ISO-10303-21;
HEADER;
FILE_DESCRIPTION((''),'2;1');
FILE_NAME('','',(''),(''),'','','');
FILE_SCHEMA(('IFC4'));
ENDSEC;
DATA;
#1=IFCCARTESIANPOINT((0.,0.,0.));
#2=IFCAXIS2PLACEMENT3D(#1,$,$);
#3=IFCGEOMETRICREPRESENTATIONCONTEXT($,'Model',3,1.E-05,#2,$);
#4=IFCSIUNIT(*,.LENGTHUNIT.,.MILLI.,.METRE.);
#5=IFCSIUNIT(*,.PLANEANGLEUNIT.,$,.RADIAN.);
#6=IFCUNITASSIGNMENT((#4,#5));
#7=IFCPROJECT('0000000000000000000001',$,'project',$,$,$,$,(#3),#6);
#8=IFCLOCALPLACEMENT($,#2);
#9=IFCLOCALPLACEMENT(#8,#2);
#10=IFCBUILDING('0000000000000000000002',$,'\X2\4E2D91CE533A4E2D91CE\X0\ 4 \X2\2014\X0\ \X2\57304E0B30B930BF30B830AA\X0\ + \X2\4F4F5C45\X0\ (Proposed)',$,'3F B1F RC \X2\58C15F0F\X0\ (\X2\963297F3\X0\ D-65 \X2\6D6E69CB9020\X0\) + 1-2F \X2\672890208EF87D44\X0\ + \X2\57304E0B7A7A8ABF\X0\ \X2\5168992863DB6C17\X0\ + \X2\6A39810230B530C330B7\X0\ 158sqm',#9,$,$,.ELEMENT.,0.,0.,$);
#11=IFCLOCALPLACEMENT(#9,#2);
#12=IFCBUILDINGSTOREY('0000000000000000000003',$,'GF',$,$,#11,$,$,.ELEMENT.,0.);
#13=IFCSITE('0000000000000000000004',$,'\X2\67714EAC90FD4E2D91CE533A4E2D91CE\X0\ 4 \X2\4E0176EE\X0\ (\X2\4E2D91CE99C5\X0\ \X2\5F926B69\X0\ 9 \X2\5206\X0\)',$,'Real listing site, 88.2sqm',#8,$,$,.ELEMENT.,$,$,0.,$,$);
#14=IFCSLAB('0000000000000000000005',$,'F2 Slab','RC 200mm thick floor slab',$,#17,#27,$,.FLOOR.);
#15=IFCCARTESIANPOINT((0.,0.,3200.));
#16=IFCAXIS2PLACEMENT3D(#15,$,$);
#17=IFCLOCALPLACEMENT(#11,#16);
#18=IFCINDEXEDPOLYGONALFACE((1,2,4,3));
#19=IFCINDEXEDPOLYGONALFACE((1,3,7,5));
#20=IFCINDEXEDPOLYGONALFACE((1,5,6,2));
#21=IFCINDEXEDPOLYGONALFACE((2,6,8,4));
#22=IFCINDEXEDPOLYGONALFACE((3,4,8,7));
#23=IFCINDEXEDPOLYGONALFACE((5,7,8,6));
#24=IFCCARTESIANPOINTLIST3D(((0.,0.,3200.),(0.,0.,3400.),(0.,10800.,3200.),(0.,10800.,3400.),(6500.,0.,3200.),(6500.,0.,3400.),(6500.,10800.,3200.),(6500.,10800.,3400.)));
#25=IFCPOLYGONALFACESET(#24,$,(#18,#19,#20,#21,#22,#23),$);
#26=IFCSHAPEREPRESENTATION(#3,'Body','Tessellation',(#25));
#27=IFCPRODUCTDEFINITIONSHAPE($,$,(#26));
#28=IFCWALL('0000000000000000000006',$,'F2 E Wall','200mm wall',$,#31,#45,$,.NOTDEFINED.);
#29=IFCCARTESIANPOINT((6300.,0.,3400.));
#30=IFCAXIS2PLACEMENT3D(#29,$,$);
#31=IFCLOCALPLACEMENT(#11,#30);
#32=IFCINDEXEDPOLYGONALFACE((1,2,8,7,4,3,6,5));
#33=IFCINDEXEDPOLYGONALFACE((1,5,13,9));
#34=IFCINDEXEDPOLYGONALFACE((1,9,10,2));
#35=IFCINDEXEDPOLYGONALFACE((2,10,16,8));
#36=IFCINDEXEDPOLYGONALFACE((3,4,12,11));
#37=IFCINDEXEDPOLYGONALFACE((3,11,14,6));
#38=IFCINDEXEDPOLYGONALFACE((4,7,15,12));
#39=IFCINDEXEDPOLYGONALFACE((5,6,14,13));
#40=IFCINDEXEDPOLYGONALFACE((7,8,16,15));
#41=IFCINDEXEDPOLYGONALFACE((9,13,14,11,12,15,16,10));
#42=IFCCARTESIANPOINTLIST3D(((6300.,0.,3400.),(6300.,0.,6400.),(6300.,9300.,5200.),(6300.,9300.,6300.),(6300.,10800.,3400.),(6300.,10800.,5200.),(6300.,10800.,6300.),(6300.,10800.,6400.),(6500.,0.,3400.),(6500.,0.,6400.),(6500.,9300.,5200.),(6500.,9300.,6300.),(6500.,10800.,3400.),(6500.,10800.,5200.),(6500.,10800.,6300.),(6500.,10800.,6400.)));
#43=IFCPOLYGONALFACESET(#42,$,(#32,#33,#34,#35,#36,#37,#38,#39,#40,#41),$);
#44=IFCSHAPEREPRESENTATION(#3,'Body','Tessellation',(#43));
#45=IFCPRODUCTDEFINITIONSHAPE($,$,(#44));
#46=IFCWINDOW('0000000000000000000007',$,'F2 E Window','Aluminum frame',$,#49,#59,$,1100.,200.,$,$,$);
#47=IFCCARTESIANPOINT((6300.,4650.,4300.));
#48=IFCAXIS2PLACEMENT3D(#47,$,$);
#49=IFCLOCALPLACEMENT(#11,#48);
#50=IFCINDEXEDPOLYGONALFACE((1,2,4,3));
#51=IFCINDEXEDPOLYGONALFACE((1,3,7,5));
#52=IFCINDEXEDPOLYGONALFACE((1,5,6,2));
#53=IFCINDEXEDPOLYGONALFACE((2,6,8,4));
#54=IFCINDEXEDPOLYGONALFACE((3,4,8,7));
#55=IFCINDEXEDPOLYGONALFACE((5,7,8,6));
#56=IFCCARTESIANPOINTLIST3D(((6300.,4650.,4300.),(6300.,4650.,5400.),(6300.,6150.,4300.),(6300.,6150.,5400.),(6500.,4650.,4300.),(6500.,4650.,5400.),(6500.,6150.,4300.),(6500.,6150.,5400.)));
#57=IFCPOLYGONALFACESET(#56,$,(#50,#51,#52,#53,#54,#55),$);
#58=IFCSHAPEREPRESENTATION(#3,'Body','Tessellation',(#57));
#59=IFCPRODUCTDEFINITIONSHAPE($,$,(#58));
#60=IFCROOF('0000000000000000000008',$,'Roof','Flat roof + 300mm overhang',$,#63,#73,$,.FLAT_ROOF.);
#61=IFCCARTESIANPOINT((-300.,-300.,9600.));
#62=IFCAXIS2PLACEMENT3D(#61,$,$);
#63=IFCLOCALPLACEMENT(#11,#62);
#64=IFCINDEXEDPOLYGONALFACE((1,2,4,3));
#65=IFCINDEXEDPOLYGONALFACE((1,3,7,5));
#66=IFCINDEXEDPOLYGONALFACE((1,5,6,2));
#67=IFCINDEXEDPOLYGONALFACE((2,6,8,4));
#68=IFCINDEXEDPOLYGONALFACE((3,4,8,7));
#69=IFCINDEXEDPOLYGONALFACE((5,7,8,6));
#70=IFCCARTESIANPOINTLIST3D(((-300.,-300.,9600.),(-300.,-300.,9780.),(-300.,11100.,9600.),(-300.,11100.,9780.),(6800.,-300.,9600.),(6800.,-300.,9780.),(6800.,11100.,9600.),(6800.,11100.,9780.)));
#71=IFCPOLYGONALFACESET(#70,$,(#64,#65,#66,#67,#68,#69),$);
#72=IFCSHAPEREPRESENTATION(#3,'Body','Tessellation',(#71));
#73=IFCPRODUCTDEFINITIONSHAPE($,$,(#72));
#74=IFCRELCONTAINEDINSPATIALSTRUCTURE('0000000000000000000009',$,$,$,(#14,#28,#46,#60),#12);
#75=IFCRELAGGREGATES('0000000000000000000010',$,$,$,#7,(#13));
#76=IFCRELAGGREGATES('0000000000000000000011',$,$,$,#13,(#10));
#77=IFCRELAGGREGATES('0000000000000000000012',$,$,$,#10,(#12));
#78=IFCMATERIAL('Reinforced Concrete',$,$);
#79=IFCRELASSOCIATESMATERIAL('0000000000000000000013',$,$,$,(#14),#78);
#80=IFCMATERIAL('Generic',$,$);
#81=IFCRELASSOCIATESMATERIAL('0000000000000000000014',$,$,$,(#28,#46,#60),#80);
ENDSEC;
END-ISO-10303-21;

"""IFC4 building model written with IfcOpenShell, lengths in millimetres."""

from ifc_helpers import new_model, si_unit, frame, frame_2d, origin, place, context, project, spatial, rectangle, extrude, material, element, fill, save


model = new_model("IFC4")

# Units and contexts
model_context = context("Model", 3, precision=1e-05, world=origin())
ifc_project = project(units=[si_unit("LENGTHUNIT", "METRE", prefix="MILLI"), si_unit("PLANEANGLEUNIT", "RADIAN")], contexts=[model_context])

# Site, building, storey
site_placement = place(None, origin())
site = spatial("IfcSite", under=ifc_project, at=site_placement, Name="東京都中野区中野 4 丁目 (中野駅 徒歩 9 分)", ObjectType="Real listing site, 88.2sqm", CompositionType="ELEMENT", RefElevation=0.0)
building_placement = place(site_placement, origin())
building = spatial("IfcBuilding", under=site, at=building_placement, Name="中野区中野 4 — 地下スタジオ + 住居 (Proposed)", ObjectType="3F B1F RC 壁式 (防音 D-65 浮構造) + 1-2F 木造軸組 + 地下空調 全館換気 + 樹脂サッシ 158sqm", CompositionType="ELEMENT", ElevationOfRefHeight=0.0, ElevationOfTerrain=0.0)
storey_placement = place(building_placement, origin())
storey = spatial("IfcBuildingStorey", under=building, at=storey_placement, Name="GF", CompositionType="ELEMENT", Elevation=0.0)

# Slab
ifc_material_1 = material(Name="Reinforced Concrete")
slab_1_placement = place(storey_placement, frame((0.0, 0.0, 3200.0)))
element("IfcSlab", 1, at=slab_1_placement, inside=storey, material=ifc_material_1, Name="F2 Slab", Description="RC 200mm thick floor slab", PredefinedType="FLOOR", context=model_context, shape_type="SweptSolid", body=[
    extrude(rectangle(XDim=6500.0, YDim=10800.0, at=frame_2d((3250.0, 5400.0))), frame((0.0, 0.0, 3200.0)), (0.0, 0.0, 1.0), 200.0),
])

# Shared definitions
ifc_material_2 = material(Name="Generic")

# Wall, opening, window
wall_1_placement = place(storey_placement, frame((6300.0, 0.0, 3400.0)))
wall_1 = element("IfcWall", 2, at=wall_1_placement, inside=storey, material=ifc_material_2, Name="F2 E Wall", Description="200mm wall", PredefinedType="NOTDEFINED", context=model_context, shape_type="SweptSolid", body=[
    extrude(rectangle(XDim=200.0, YDim=10800.0, at=frame_2d((100.0, 5400.0))), frame((6300.0, 0.0, 3400.0)), (0.0, 0.0, 1.0), 3000.0),
])
opening_1_placement = place(storey_placement, frame((6300.0, 4650.0, 4300.0)))
opening_1 = element("IfcOpeningElement", 3, at=opening_1_placement, cuts=wall_1, PredefinedType="NOTDEFINED", context=model_context, shape_type="SweptSolid", body=[
    extrude(rectangle(XDim=200.0, YDim=1500.0, at=frame_2d((100.0, 750.0))), frame((6300.0, 4650.0, 4300.0)), (0.0, 0.0, 1.0), 1100.0),
])
window_1_placement = place(storey_placement, frame((6300.0, 4650.0, 4300.0)))
window_1 = element("IfcWindow", 4, at=window_1_placement, inside=storey, material=ifc_material_2, Name="F2 E Window", Description="Aluminum frame", OverallHeight=1100.0, OverallWidth=200.0, context=model_context, shape_type="SweptSolid", body=[
    extrude(rectangle(XDim=200.0, YDim=1500.0, at=frame_2d((100.0, 750.0))), frame((6300.0, 4650.0, 4300.0)), (0.0, 0.0, 1.0), 1100.0),
])
fill(opening_1, window_1)

# Roof
roof_placement = place(storey_placement, frame((-300.0, -300.0, 9600.0)))
element("IfcRoof", 5, at=roof_placement, inside=storey, material=ifc_material_2, Name="Roof", Description="Flat roof + 300mm overhang", PredefinedType="FLAT_ROOF", context=model_context, shape_type="SweptSolid", body=[
    extrude(rectangle(XDim=7100.0, YDim=11400.0, at=frame_2d((3550.0, 5700.0))), frame((-300.0, -300.0, 9600.0)), (0.0, 0.0, 1.0), 180.0),
])

save(model, "model.ifc")
